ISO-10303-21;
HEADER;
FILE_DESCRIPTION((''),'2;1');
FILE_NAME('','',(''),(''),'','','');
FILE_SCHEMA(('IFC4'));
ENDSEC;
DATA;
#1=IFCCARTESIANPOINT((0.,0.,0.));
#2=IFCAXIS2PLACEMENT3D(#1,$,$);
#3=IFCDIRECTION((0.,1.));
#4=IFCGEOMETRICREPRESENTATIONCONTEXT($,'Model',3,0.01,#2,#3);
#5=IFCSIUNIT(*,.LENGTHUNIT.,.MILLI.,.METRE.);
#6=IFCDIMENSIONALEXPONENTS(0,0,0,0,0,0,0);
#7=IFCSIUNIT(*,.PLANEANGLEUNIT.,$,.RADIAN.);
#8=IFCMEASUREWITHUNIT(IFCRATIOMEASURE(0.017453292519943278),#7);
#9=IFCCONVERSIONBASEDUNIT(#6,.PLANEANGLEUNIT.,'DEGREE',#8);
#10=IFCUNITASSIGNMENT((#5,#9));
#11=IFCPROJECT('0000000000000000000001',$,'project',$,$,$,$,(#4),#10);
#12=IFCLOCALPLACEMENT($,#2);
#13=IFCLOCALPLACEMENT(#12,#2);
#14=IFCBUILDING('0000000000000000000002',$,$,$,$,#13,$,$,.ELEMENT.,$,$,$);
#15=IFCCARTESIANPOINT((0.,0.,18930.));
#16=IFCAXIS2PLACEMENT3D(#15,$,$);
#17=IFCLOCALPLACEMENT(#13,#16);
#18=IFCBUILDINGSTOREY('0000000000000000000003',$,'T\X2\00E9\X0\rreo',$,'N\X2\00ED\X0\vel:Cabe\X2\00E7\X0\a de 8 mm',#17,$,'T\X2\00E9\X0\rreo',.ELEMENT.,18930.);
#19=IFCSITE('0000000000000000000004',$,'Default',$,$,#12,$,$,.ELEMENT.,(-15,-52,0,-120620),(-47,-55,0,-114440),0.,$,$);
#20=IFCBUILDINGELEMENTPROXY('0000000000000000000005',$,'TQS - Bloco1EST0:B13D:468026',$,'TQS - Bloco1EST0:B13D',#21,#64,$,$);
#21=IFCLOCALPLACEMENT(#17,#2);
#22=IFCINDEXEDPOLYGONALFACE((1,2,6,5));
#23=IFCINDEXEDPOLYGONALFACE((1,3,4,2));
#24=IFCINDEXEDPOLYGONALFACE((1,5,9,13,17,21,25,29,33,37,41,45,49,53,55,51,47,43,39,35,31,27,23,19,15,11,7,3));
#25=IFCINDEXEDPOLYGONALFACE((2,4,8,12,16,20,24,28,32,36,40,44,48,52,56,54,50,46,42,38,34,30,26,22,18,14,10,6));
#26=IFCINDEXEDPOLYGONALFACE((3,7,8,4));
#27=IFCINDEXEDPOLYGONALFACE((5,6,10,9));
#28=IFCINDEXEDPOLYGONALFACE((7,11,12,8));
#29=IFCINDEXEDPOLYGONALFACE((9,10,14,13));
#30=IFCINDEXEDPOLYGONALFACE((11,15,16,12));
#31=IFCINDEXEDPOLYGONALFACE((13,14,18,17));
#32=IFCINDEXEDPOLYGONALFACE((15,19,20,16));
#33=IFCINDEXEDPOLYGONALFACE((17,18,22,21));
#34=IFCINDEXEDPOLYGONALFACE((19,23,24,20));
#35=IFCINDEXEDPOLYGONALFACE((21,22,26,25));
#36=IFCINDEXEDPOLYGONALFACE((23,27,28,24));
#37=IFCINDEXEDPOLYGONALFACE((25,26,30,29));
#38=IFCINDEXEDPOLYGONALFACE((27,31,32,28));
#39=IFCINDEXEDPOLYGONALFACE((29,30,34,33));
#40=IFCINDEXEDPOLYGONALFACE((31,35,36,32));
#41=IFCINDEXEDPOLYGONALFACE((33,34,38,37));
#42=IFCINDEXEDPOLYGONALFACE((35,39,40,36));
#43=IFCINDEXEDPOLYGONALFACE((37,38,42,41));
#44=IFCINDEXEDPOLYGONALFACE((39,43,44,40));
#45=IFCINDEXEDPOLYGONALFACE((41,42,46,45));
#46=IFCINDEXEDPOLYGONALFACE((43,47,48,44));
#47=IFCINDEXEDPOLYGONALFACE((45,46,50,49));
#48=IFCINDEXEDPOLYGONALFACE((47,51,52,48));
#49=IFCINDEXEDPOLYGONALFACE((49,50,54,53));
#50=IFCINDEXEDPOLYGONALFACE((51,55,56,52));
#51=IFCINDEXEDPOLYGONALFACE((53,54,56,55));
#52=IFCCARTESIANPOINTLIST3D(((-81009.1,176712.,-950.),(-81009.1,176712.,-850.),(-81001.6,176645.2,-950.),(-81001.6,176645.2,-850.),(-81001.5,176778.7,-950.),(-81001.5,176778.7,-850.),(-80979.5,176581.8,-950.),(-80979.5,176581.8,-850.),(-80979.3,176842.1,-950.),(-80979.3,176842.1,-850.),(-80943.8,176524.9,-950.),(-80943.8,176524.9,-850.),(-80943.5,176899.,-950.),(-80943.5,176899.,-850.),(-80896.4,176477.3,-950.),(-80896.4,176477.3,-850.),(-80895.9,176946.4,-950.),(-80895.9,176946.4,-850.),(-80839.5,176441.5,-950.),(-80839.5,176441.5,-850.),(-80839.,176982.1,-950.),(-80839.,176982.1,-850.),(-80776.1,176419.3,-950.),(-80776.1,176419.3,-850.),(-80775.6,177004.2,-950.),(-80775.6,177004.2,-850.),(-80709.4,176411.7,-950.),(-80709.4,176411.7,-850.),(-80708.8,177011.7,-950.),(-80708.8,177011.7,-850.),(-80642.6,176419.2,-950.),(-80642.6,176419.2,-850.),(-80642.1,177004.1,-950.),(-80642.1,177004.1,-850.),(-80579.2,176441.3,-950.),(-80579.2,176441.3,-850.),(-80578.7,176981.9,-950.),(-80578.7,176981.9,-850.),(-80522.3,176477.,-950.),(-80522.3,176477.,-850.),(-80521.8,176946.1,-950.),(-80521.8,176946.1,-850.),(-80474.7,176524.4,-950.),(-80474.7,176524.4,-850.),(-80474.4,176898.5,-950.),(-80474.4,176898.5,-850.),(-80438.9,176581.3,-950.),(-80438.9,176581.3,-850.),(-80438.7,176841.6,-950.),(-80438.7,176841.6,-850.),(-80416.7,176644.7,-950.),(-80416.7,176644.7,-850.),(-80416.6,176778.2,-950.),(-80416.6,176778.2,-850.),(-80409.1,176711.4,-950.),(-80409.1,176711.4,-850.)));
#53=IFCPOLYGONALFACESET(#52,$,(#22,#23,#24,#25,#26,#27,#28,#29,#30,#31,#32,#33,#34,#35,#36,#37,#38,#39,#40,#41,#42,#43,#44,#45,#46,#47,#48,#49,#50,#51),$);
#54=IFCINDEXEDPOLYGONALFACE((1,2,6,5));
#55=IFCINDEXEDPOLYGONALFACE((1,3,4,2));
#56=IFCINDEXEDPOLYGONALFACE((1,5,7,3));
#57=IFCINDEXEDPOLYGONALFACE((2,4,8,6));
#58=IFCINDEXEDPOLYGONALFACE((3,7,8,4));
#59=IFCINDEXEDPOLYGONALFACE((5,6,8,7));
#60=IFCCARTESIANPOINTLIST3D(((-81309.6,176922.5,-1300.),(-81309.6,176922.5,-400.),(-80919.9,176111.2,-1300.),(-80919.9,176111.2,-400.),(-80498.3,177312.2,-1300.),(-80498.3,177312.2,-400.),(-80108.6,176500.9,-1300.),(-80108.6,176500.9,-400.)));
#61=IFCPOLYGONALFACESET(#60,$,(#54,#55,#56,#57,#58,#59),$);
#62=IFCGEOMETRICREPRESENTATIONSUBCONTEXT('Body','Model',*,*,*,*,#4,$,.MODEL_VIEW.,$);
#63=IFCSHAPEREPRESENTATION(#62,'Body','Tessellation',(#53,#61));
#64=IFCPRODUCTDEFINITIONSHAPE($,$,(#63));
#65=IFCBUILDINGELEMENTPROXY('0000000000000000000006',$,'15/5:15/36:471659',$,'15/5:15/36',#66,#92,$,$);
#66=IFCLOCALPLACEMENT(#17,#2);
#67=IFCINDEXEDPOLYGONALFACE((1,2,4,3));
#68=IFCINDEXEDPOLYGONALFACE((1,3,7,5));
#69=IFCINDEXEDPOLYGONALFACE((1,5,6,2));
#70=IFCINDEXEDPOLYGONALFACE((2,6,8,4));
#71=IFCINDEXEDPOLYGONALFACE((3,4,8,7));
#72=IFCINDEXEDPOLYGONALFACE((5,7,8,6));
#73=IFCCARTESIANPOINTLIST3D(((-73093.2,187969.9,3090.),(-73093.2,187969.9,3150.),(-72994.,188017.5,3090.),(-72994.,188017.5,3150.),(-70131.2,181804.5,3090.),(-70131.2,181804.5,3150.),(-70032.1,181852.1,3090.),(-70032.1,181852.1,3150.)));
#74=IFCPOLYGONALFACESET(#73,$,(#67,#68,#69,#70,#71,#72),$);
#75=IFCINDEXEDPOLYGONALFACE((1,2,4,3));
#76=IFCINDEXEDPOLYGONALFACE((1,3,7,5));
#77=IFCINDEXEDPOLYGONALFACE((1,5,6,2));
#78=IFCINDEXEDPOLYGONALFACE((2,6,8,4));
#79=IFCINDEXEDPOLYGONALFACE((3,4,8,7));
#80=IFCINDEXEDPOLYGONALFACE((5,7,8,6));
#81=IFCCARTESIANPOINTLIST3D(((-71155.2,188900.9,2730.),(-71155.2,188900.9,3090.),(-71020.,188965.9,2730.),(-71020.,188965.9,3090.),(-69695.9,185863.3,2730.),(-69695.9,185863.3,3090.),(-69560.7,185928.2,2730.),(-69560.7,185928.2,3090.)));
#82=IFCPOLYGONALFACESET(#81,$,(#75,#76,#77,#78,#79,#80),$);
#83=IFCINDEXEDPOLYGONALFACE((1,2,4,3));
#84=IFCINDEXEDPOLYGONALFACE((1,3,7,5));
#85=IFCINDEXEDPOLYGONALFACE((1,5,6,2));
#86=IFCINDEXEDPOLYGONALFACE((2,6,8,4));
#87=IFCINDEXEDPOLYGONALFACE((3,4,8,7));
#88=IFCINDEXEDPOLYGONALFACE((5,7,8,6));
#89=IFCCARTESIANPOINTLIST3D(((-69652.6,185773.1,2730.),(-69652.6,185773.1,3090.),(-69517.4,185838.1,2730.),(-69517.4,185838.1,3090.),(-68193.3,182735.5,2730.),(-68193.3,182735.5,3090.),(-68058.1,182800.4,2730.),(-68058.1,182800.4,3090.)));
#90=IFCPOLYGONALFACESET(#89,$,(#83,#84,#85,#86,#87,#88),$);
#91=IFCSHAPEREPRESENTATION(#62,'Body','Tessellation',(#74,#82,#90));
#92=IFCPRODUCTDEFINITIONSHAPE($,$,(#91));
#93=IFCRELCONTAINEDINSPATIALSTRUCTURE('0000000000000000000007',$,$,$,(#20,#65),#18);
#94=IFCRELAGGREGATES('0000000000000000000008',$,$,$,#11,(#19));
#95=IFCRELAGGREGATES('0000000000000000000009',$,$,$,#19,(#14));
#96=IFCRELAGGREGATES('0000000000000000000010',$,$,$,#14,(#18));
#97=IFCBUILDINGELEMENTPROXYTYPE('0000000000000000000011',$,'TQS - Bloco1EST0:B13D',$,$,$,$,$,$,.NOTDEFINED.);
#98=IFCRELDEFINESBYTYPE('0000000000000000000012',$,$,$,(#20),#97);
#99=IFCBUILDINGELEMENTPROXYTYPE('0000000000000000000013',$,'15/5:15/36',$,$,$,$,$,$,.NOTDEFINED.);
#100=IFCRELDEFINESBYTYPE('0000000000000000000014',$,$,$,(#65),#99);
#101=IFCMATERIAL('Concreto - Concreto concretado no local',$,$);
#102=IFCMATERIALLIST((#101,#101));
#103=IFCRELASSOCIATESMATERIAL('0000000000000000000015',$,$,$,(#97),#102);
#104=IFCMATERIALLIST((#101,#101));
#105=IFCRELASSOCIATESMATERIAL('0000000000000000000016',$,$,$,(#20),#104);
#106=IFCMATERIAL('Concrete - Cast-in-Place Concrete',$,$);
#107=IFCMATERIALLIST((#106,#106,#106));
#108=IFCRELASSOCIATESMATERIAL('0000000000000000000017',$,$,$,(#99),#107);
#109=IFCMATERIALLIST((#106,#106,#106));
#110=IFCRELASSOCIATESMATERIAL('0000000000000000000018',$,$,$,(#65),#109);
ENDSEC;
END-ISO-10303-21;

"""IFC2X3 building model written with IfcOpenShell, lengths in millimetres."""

from ifc_helpers import new_model, entity, si_unit, converted_unit, direction, frame, frame_2d, origin, origin_2d_with_axis, place, context, subcontext, project, spatial, rectangle, circle, extrude, source, transform, mapped, material, material_list, type_object, type_shapes, element, save


model = new_model("IFC2X3")

# Units and contexts
model_context = context("Model", 3, precision=0.01, world=origin(), true_north=direction((0.0, 1.0)))
body_context = subcontext(model_context, "Body", "Model", "MODEL_VIEW")
ifc_project = project(units=[si_unit("LENGTHUNIT", "METRE", prefix="MILLI"), converted_unit("PLANEANGLEUNIT", "DEGREE", entity("IfcRatioMeasure", 0.017453292519943278), si_unit("PLANEANGLEUNIT", "RADIAN"), dimensions=[0, 0, 0, 0, 0, 0, 0])], contexts=[model_context])

# Site, building, storey
site_placement = place(None, origin())
site = spatial("IfcSite", under=ifc_project, at=site_placement, Name="Default", CompositionType="ELEMENT", RefLatitude=(-15, -52, 0, -120620), RefLongitude=(-47, -55, 0, -114440), RefElevation=0.0)
building_placement = place(site_placement, origin())
building = spatial("IfcBuilding", under=site, at=building_placement, CompositionType="ELEMENT")
storey_placement = place(building_placement, frame((0.0, 0.0, 18930.0)))
storey = spatial("IfcBuildingStorey", under=building, at=storey_placement, Name="Térreo", ObjectType="Nível:Cabeça de 8 mm", LongName="Térreo", CompositionType="ELEMENT", Elevation=18930.0)

# Building element proxies
ifc_material_1 = material(Name="Concreto - Concreto concretado no local")
ifc_material_list_1 = material_list([ifc_material_1, ifc_material_1])
ifc_material_list_2 = material_list([ifc_material_1, ifc_material_1])
building_element_proxy_type_1 = type_object("IfcBuildingElementProxyType", Name="TQS - Bloco1EST0:B13D", PredefinedType="NOTDEFINED", material=ifc_material_list_2)
shared_shape_1 = source(origin(), body_context, "Body", "SweptSolid", [
    extrude(circle(Radius=300.0, at=frame_2d((0.0, 0.0), x_axis=(1.0, 0.0))), frame((0.0, 0.0, -550.0)), (0.0, 0.0, 1.0), 100.0),
    extrude(rectangle(XDim=900.0, YDim=900.0, at=origin_2d_with_axis()), frame((0.0, 0.0, -900.0), z_axis=(0.0, 0.0, 1.0), x_axis=(-1.0, 0.0, 0.0)), (0.0, 0.0, 1.0), 900.0),
])
type_shapes(building_element_proxy_type_1, [shared_shape_1])
proxy_1_placement = place(storey_placement, frame((-80709.1, 176711.7, -400.0), z_axis=(0.0, 0.0, 1.0), x_axis=(-0.43303, 0.90138, 0.0)))
element("IfcBuildingElementProxy", 1, at=proxy_1_placement, inside=storey, type_object=building_element_proxy_type_1, material=ifc_material_list_1, Name="TQS - Bloco1EST0:B13D:468026", ObjectType="TQS - Bloco1EST0:B13D", context=body_context, shape_type="MappedRepresentation", body=[
    mapped(shared_shape_1, transform((0.0, 0.0, 0.0), scale=1.0)),
])
ifc_material_2 = material(Name="Concrete - Cast-in-Place Concrete")
ifc_material_list_3 = material_list([ifc_material_2, ifc_material_2, ifc_material_2])
ifc_material_list_4 = material_list([ifc_material_2, ifc_material_2, ifc_material_2])
building_element_proxy_type_2 = type_object("IfcBuildingElementProxyType", Name="15/5:15/36", PredefinedType="NOTDEFINED", material=ifc_material_list_4)
shared_shape_2 = source(origin(), body_context, "Body", "SweptSolid", [
    extrude(rectangle(XDim=110.0, YDim=6840.0, at=frame_2d((0.0, 0.0), x_axis=(1.0, 0.0))), frame((1530.5, 3106.5, 360.0), z_axis=(0.0, 0.0, 1.0), x_axis=(0.90138, 0.43303, 0.0)), (0.0, 0.0, 1.0), 60.0),
    extrude(rectangle(XDim=3370.0, YDim=150.0, at=frame_2d((0.0, 0.0), x_axis=(1.0, 0.0))), frame((2735.2, 5610.1, 0.0), z_axis=(0.0, 0.0, 1.0), x_axis=(0.43303, -0.90138, 0.0)), (0.0, 0.0, 1.0), 360.0),
    extrude(rectangle(XDim=3370.0, YDim=150.0, at=frame_2d((0.0, 0.0), x_axis=(1.0, 0.0))), frame((4237.8, 2482.3, 0.0), z_axis=(0.0, 0.0, 1.0), x_axis=(0.43303, -0.90138, 0.0)), (0.0, 0.0, 1.0), 360.0),
])
type_shapes(building_element_proxy_type_2, [shared_shape_2])
proxy_2_placement = place(storey_placement, frame((-73093.2, 181804.5, 2730.0)))
element("IfcBuildingElementProxy", 2, at=proxy_2_placement, inside=storey, type_object=building_element_proxy_type_2, material=ifc_material_list_3, Name="15/5:15/36:471659", ObjectType="15/5:15/36", context=body_context, shape_type="MappedRepresentation", body=[
    mapped(shared_shape_2, transform((0.0, 0.0, 0.0), scale=1.0)),
])

save(model, "model.ifc")
